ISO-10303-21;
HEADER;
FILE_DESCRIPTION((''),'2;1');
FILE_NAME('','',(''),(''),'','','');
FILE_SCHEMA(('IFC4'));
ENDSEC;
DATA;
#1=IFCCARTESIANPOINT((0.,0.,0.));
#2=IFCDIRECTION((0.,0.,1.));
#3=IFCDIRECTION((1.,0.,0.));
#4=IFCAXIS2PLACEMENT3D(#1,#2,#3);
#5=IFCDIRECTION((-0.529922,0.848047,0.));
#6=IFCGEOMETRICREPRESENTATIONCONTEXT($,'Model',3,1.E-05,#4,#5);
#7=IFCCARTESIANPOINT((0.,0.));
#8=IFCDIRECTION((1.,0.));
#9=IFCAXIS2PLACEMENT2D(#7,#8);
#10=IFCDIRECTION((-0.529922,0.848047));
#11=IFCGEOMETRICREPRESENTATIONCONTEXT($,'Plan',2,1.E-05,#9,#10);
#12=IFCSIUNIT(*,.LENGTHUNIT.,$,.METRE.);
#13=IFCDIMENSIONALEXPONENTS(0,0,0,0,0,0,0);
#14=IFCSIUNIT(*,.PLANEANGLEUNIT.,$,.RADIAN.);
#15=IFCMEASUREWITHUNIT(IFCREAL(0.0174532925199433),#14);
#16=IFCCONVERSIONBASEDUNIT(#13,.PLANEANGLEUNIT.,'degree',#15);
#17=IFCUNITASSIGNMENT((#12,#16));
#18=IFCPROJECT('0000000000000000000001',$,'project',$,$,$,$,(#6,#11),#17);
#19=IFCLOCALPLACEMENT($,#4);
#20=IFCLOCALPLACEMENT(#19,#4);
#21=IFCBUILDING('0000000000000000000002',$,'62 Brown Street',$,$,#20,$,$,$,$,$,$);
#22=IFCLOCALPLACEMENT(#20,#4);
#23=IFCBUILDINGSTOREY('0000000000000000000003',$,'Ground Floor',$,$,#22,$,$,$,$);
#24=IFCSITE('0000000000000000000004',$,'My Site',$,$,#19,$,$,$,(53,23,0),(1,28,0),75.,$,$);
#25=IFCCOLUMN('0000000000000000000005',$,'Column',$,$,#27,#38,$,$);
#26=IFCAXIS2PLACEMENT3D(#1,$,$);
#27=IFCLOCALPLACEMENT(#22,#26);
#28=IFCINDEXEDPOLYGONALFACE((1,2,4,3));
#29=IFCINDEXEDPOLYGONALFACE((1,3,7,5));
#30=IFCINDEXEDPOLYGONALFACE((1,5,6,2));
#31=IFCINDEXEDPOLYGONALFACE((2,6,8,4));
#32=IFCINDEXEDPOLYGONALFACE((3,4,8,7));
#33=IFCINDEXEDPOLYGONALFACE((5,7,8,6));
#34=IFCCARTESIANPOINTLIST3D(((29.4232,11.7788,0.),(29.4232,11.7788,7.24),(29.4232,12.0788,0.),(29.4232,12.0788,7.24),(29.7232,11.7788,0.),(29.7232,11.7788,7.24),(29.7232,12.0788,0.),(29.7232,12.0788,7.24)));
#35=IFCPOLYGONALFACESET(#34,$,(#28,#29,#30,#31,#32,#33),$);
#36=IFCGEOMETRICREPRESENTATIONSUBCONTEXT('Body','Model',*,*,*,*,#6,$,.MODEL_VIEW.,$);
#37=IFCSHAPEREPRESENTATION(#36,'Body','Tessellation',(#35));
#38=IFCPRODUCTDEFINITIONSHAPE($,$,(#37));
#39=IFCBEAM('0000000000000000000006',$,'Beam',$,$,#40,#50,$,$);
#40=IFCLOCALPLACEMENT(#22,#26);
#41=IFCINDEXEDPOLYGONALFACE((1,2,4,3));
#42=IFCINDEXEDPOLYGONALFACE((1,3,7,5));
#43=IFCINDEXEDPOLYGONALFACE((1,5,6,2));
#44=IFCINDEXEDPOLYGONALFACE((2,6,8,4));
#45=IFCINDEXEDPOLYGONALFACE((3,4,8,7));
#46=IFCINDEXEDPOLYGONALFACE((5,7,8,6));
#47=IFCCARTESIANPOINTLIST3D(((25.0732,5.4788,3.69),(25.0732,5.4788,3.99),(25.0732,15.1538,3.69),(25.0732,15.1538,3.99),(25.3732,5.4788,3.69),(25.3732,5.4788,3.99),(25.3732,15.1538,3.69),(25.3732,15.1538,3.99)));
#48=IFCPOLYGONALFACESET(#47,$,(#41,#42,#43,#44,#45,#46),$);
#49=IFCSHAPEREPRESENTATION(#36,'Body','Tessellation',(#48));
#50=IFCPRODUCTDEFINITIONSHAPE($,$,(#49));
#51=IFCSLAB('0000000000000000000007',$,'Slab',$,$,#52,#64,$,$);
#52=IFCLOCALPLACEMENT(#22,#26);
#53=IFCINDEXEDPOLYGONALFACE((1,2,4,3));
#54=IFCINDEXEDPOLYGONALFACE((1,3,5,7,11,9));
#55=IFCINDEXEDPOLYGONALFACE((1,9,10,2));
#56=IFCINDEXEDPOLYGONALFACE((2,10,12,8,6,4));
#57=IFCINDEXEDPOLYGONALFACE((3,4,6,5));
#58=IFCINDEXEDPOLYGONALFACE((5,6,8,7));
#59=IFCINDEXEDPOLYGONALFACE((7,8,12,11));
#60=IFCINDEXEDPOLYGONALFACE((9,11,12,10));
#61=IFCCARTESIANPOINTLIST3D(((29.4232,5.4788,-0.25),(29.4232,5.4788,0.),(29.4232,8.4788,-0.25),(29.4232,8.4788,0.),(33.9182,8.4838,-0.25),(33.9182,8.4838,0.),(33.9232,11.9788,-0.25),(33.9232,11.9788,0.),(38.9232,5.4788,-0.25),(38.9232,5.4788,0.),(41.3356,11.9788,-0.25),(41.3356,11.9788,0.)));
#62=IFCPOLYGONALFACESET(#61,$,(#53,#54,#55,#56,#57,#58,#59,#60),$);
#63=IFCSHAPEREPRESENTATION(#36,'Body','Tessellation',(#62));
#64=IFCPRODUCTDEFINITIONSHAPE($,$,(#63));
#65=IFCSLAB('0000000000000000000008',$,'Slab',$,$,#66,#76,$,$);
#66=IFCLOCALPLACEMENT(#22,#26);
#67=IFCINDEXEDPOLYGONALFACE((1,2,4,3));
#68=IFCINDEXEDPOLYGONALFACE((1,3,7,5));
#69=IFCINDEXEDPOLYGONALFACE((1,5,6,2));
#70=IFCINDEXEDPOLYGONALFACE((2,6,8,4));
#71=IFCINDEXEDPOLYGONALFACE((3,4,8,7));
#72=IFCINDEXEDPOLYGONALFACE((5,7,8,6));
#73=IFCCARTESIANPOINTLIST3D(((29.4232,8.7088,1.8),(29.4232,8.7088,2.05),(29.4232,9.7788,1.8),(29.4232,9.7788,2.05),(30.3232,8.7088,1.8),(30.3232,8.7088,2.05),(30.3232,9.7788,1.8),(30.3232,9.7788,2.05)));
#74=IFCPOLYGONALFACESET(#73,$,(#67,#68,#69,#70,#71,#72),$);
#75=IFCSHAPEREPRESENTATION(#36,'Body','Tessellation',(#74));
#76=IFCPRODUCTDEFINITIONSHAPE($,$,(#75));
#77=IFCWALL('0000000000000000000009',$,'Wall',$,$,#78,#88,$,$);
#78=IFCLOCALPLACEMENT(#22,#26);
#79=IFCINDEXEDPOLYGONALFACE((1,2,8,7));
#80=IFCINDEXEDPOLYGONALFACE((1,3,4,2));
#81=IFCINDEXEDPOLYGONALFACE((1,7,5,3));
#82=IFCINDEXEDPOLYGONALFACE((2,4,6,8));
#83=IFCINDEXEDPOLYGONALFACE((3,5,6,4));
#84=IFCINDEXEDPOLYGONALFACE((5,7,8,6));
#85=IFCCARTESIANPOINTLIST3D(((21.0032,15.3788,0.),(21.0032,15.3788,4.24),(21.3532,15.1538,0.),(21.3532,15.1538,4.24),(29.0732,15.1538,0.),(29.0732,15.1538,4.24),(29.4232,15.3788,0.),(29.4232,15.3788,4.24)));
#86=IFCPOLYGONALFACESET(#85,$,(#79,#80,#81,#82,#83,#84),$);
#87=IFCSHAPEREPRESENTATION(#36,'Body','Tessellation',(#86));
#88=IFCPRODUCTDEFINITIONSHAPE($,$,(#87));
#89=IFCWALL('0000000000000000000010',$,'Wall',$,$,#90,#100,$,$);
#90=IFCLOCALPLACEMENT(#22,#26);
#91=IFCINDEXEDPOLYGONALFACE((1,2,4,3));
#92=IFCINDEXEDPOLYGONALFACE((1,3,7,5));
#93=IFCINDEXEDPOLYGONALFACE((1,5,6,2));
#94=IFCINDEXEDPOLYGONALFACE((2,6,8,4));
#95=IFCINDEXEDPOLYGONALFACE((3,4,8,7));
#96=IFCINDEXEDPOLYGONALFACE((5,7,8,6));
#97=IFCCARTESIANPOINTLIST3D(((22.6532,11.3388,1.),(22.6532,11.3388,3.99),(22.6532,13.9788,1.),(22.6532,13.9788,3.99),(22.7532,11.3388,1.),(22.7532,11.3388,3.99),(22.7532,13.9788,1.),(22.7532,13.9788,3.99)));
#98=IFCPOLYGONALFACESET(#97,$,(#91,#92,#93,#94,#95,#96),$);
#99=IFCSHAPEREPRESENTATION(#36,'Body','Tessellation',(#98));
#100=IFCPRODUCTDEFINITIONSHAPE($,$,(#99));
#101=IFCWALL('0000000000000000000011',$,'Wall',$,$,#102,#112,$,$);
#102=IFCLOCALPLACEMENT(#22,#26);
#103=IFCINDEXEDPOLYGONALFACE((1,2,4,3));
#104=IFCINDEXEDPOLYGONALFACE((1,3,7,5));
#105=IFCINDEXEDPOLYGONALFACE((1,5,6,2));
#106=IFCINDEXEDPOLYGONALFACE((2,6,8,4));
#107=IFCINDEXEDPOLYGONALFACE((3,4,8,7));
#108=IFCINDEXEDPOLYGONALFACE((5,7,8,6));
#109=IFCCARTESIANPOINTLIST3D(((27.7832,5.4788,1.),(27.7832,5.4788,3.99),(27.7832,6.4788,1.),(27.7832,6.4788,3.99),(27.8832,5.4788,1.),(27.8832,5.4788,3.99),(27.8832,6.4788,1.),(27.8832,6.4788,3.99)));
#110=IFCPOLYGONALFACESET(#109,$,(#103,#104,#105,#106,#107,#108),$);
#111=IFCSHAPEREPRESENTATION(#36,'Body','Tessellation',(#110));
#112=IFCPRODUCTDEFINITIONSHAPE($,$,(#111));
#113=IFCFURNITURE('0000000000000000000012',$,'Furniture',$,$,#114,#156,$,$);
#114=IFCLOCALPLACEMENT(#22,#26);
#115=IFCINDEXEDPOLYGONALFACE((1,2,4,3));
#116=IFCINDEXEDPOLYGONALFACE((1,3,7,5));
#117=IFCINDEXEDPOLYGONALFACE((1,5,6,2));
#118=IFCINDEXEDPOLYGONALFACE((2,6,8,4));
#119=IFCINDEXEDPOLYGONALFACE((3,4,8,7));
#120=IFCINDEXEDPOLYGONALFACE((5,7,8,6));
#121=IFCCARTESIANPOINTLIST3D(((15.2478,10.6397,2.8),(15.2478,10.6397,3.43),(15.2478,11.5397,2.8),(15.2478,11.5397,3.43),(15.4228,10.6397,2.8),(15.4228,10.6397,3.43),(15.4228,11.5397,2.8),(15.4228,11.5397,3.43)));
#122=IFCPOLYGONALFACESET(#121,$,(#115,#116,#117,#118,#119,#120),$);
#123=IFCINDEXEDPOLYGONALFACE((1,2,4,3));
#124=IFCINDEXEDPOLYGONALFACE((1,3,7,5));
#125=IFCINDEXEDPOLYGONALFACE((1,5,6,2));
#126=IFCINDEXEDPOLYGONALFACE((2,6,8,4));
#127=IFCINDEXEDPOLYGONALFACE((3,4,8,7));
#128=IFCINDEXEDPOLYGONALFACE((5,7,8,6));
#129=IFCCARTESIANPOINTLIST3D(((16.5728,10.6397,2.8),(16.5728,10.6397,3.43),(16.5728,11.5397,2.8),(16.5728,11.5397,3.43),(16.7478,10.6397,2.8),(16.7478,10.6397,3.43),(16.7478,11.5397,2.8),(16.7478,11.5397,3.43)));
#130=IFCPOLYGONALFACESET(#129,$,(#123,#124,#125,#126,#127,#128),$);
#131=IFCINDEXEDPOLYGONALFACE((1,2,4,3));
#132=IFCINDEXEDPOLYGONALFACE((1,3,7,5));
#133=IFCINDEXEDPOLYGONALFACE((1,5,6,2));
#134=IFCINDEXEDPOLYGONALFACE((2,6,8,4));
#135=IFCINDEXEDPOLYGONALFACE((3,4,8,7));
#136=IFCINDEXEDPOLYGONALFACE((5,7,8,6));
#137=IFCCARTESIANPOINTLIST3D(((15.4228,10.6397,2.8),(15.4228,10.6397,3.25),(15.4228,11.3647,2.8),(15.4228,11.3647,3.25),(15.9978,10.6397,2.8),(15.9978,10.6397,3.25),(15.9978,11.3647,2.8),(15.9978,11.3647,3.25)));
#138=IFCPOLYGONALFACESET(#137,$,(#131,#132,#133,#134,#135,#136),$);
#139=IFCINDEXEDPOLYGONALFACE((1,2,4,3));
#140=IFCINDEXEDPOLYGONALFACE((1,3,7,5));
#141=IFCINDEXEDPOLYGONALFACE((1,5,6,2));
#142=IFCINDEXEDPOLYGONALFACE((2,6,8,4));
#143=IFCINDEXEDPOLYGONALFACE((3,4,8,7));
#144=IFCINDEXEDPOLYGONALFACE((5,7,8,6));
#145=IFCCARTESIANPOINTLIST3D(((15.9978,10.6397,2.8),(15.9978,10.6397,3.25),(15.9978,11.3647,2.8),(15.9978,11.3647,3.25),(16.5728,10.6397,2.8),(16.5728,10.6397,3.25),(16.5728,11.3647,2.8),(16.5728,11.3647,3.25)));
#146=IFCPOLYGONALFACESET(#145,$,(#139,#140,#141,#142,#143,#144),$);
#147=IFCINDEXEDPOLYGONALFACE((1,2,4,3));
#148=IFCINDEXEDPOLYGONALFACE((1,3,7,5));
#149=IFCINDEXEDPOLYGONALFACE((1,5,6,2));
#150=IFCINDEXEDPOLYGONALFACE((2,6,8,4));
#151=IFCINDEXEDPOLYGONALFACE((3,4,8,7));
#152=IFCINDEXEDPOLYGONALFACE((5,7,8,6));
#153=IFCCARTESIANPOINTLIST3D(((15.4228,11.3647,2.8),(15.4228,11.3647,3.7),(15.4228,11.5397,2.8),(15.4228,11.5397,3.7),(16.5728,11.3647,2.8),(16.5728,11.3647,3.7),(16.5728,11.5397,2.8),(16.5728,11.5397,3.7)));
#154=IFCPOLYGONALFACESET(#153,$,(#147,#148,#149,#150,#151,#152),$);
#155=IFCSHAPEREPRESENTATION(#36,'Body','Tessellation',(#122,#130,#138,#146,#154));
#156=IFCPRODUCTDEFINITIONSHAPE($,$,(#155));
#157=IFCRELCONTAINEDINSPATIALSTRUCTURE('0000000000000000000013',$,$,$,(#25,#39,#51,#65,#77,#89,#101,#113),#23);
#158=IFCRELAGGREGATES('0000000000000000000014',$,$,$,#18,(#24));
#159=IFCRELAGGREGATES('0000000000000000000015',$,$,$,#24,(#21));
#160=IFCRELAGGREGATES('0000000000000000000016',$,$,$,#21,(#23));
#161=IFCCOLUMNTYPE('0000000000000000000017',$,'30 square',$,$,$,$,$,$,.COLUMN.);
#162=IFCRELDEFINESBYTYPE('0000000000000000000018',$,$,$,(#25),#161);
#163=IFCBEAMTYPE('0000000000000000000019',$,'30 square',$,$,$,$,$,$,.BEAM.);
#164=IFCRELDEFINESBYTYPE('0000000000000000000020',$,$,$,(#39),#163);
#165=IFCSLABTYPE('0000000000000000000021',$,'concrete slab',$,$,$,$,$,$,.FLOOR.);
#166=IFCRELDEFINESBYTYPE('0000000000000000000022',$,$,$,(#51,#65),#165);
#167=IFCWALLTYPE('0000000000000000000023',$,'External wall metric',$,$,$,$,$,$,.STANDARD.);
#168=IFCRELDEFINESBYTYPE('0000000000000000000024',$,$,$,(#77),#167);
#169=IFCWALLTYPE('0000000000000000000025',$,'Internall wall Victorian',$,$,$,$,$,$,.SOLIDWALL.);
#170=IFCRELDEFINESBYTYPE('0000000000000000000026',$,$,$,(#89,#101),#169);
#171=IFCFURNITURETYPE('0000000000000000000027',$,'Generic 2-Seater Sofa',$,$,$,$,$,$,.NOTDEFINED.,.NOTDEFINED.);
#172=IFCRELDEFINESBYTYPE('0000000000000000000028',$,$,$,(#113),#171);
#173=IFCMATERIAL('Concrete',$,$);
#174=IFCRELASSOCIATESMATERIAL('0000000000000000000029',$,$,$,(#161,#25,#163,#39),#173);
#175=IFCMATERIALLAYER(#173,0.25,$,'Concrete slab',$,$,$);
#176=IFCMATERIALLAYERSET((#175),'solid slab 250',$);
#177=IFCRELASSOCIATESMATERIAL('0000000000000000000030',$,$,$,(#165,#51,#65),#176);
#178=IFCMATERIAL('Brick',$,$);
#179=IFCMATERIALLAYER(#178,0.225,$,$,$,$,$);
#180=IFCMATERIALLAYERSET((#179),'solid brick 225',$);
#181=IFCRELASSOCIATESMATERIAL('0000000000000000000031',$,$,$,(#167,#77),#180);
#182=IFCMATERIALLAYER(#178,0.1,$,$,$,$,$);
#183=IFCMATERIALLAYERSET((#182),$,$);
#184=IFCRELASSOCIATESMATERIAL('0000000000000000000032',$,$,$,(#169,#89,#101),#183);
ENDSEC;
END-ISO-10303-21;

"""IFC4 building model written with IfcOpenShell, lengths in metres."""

from ifc_helpers import new_model, entity, si_unit, converted_unit, direction, frame, origin_with_axes, origin_2d_with_axis, place, context, subcontext, project, spatial, line, indexed_curve, rectangle, outline, extrude, clip, halfspace, shape, source, transform, mapped, material, layer, layer_set, layer_usage, material_profile, profile_set, profile_usage, type_object, type_shapes, element, save


model = new_model("IFC4")

# Units and contexts
model_context = context("Model", 3, precision=1e-05, world=origin_with_axes(), true_north=direction((-0.529922, 0.848047, 0.0)))
plan_context = context("Plan", 2, precision=1e-05, world=origin_2d_with_axis(), true_north=direction((-0.529922, 0.848047)))
body_context_1 = subcontext(model_context, "Body", "Model", "MODEL_VIEW")
body_context_2 = subcontext(plan_context, "Body", "Plan", "PLAN_VIEW")
ifc_project = project(units=[si_unit("LENGTHUNIT", "METRE"), converted_unit("PLANEANGLEUNIT", "degree", entity("IfcReal", 0.0174532925199433), si_unit("PLANEANGLEUNIT", "RADIAN"), dimensions=[0, 0, 0, 0, 0, 0, 0])], contexts=[model_context, plan_context])

# Site, building, storey
site_placement = place(None, origin_with_axes())
site = spatial("IfcSite", under=ifc_project, at=site_placement, Name="My Site", RefLatitude=(53, 23, 0), RefLongitude=(1, 28, 0), RefElevation=75.0)
building_placement = place(site_placement, origin_with_axes())
building = spatial("IfcBuilding", under=site, at=building_placement, Name="62 Brown Street")
storey_placement = place(building_placement, origin_with_axes())
storey = spatial("IfcBuildingStorey", under=building, at=storey_placement, Name="Ground Floor")

# Column
ifc_material_1 = material(Name="Concrete")
ifc_material_profile_1 = material_profile(ifc_material_1, rectangle(XDim=0.3, YDim=0.3))
ifc_profile_set_1 = profile_set([ifc_material_profile_1])
ifc_profile_usage_1 = profile_usage(ifc_profile_set_1, cardinal=5)
column_type = type_object("IfcColumnType", Name="30 square", PredefinedType="COLUMN", material=ifc_profile_set_1)
column_1_placement = place(storey_placement, frame((29.5732, 11.9288, 0.0), z_axis=(0.0, 0.0, 1.0), x_axis=(1.0, 0.0, 0.0)))
element("IfcColumn", 1, at=column_1_placement, inside=storey, type_object=column_type, material=ifc_profile_usage_1, Name="Column", context=body_context_1, shape_type="SweptSolid", body=[
    extrude(rectangle(XDim=0.3, YDim=0.3), origin_with_axes(), (0.0, 0.0, 1.0), 7.24),
])

# Beam
ifc_material_profile_2 = material_profile(ifc_material_1, rectangle(XDim=0.3, YDim=0.3))
ifc_profile_set_2 = profile_set([ifc_material_profile_2])
ifc_profile_usage_2 = profile_usage(ifc_profile_set_2, cardinal=5)
beam_type = type_object("IfcBeamType", Name="30 square", PredefinedType="BEAM", material=ifc_profile_set_2)
beam_placement = place(storey_placement, frame((25.2232, 5.4788, 3.84), z_axis=(0.0, 1.0, 0.0), x_axis=(-1.0, 0.0, 0.0)))
element("IfcBeam", 2, at=beam_placement, inside=storey, type_object=beam_type, material=ifc_profile_usage_2, Name="Beam", context=body_context_1, shape_type="SweptSolid", body=[
    extrude(rectangle(XDim=0.3, YDim=0.3), origin_with_axes(), (0.0, 0.0, 1.0), 9.675),
])

# Slabs
ifc_layer_1 = layer(ifc_material_1, 0.25, Name="Concrete slab")
ifc_layer_set_1 = layer_set([ifc_layer_1], Name="solid slab 250")
ifc_layer_usage_1 = layer_usage(ifc_layer_set_1, "AXIS3", "POSITIVE", 0.0)
slab_type_1 = type_object("IfcSlabType", Name="concrete slab", PredefinedType="FLOOR", material=ifc_layer_set_1)
slab_1_placement = place(storey_placement, frame((29.4232, 5.4788, -0.25), z_axis=(0.0, 0.0, 1.0), x_axis=(1.0, 0.0, 0.0)))
element("IfcSlab", 3, at=slab_1_placement, inside=storey, type_object=slab_type_1, material=ifc_layer_usage_1, Name="Slab", context=body_context_1, shape_type="SweptSolid", body=[
    extrude(outline(indexed_curve([(0.0, 0.0), (9.5, 0.0), (11.9124, 6.5), (0.0, 3.0), (4.5, 6.5), (4.495, 3.005)], segments=[line(1, 2), line(2, 3), line(3, 5), line(5, 6), line(6, 4), line(4, 1)], self_intersect=False)), None, (0.0, 0.0, 1.0), 0.25),
])
ifc_layer_usage_2 = layer_usage(ifc_layer_set_1, "AXIS3", "POSITIVE", 0.0)
slab_2_placement = place(storey_placement, frame((29.4232, 8.7088, 1.8), z_axis=(0.0, 0.0, 1.0), x_axis=(1.0, 0.0, 0.0)))
element("IfcSlab", 4, at=slab_2_placement, inside=storey, type_object=slab_type_1, material=ifc_layer_usage_2, Name="Slab", context=body_context_1, shape_type="SweptSolid", body=[
    extrude(outline(indexed_curve([(0.9, 1.07), (0.9, 0.0), (0.0, 0.0), (0.0, 1.07)], segments=[line(3, 2), line(2, 1), line(1, 4), line(4, 3)], self_intersect=False)), None, (0.0, 0.0, 1.0), 0.25),
])

# Walls
ifc_material_2 = material(Name="Brick")
ifc_layer_2 = layer(ifc_material_2, 0.225)
ifc_layer_set_2 = layer_set([ifc_layer_2], Name="solid brick 225")
wall_type_1 = type_object("IfcWallType", Name="External wall metric", PredefinedType="STANDARD", material=ifc_layer_set_2)
ifc_layer_usage_3 = layer_usage(ifc_layer_set_2, "AXIS2", "POSITIVE", 0.0)
wall_1_placement = place(storey_placement, frame((29.4232, 15.3788, 0.0), z_axis=(0.0, 0.0, 1.0), x_axis=(-1.0, 0.0, 0.0)))
element("IfcWall", 5, at=wall_1_placement, inside=storey, type_object=wall_type_1, material=ifc_layer_usage_3, Name="Wall", context=body_context_1, shape_type="Clipping", body=[
    clip(clip(extrude(outline(indexed_curve([(0.0, 0.0), (0.0, 0.225), (8.42, 0.225), (8.42, 0.0), (0.0, 0.0)], self_intersect=False)), origin_with_axes(), (0.0, 0.0, 1.0), 4.24), halfspace(frame((8.42, 0.0, 0.0), z_axis=(0.540756, 0.841179, 0.0), x_axis=(-0.841179, 0.540756, 0.0)), False)), halfspace(frame((0.0, 0.0, 0.0), z_axis=(-0.540758, 0.841178, 0.0), x_axis=(0.841178, 0.540758, 0.0)), False)),
])
ifc_layer_3 = layer(ifc_material_2, 0.1)
ifc_layer_set_3 = layer_set([ifc_layer_3])
ifc_layer_usage_4 = layer_usage(ifc_layer_set_3, "AXIS2", "POSITIVE", 0.0)
wall_type_2 = type_object("IfcWallType", Name="Internall wall Victorian", PredefinedType="SOLIDWALL", material=ifc_layer_set_3)
wall_2_placement = place(storey_placement, frame((22.7532, 11.3388, 1.0), z_axis=(0.0, 0.0, 1.0), x_axis=(0.0, 1.0, 0.0)))
element("IfcWall", 6, at=wall_2_placement, inside=storey, type_object=wall_type_2, material=ifc_layer_usage_4, Name="Wall", context=body_context_1, shape_type="SweptSolid", body=[
    extrude(outline(indexed_curve([(0.0, 0.0), (0.0, 0.1), (2.64, 0.1), (2.64, 0.0), (0.0, 0.0)], self_intersect=False)), origin_with_axes(), (0.0, 0.0, 1.0), 2.99),
])
ifc_layer_usage_5 = layer_usage(ifc_layer_set_3, "AXIS2", "POSITIVE", 0.0)
wall_3_placement = place(storey_placement, frame((27.8832, 5.4788, 1.0), z_axis=(0.0, 0.0, 1.0), x_axis=(0.0, 1.0, 0.0)))
element("IfcWall", 7, at=wall_3_placement, inside=storey, type_object=wall_type_2, material=ifc_layer_usage_5, Name="Wall", context=body_context_1, shape_type="SweptSolid", body=[
    extrude(outline(indexed_curve([(0.0, 0.0), (0.0, 0.1), (1.0, 0.1), (1.0, 0.0), (0.0, 0.0)], self_intersect=False)), origin_with_axes(), (0.0, 0.0, 1.0), 2.99),
])

# Furniture
furniture_type_1 = type_object("IfcFurnitureType", Name="Generic 2-Seater Sofa", AssemblyPlace="NOTDEFINED", PredefinedType="NOTDEFINED")
shared_shape_1 = source(origin_with_axes(), body_context_1, "Body", "SweptSolid", [
    extrude(outline(indexed_curve([(0.0, 0.0), (0.175, 0.0), (0.175, 0.9), (0.0, 0.9)], segments=[line(1, 2, 3, 4, 1)])), frame((-0.75, -0.9, 0.0), z_axis=(0.0, 0.0, 1.0), x_axis=(1.0, 0.0, 0.0)), (0.0, 0.0, 1.0), 0.63),
    extrude(outline(indexed_curve([(0.0, 0.0), (0.175, 0.0), (0.175, 0.9), (0.0, 0.9)], segments=[line(1, 2, 3, 4, 1)])), frame((0.575, -0.9, 0.0), z_axis=(0.0, 0.0, 1.0), x_axis=(1.0, 0.0, 0.0)), (0.0, 0.0, 1.0), 0.63),
    extrude(outline(indexed_curve([(0.175, 0.0), (0.75, 0.0), (0.75, 0.725), (0.175, 0.725)], segments=[line(1, 2, 3, 4, 1)])), frame((-0.75, -0.9, 0.0), z_axis=(0.0, 0.0, 1.0), x_axis=(1.0, 0.0, 0.0)), (0.0, 0.0, 1.0), 0.45),
    extrude(outline(indexed_curve([(0.75, 0.0), (1.325, 0.0), (1.325, 0.725), (0.75, 0.725)], segments=[line(1, 2, 3, 4, 1)])), frame((-0.75, -0.9, 0.0), z_axis=(0.0, 0.0, 1.0), x_axis=(1.0, 0.0, 0.0)), (0.0, 0.0, 1.0), 0.45),
    extrude(outline(indexed_curve([(0.175, 0.725), (1.325, 0.725), (1.325, 0.9), (0.175, 0.9)], segments=[line(1, 2, 3, 4, 1)])), frame((-0.75, -0.9, 0.0), z_axis=(0.0, 0.0, 1.0), x_axis=(1.0, 0.0, 0.0)), (0.0, 0.0, 1.0), 0.9),
])
shared_shape_2 = source(origin_with_axes(), body_context_2, "Body", "Curve2D", [
    entity("IfcIndexedPolyCurve", entity("IfcCartesianPointList2D", [[-0.75, -0.9], [-0.575, -0.9], [-0.575, 0.0], [-0.75, 0.0]]), [entity("IfcLineIndex", [1, 2, 3, 4, 1])]),
    entity("IfcIndexedPolyCurve", entity("IfcCartesianPointList2D", [[0.575, -0.9], [0.75, -0.9], [0.75, 0.0], [0.575, 0.0]]), [entity("IfcLineIndex", [1, 2, 3, 4, 1])]),
    entity("IfcIndexedPolyCurve", entity("IfcCartesianPointList2D", [[-0.575, -0.9], [0.0, -0.9], [0.0, -0.175], [-0.575, -0.175]]), [entity("IfcLineIndex", [1, 2, 3, 4, 1])]),
    entity("IfcIndexedPolyCurve", entity("IfcCartesianPointList2D", [[0.0, -0.9], [0.575, -0.9], [0.575, -0.175], [0.0, -0.175]]), [entity("IfcLineIndex", [1, 2, 3, 4, 1])]),
    entity("IfcIndexedPolyCurve", entity("IfcCartesianPointList2D", [[-0.575, -0.175], [0.575, -0.175], [0.575, 0.0], [-0.575, 0.0]]), [entity("IfcLineIndex", [1, 2, 3, 4, 1])]),
])
type_shapes(furniture_type_1, [shared_shape_1, shared_shape_2])
furniture_1_placement = place(storey_placement, frame((15.9978, 11.5397, 2.8), z_axis=(0.0, 0.0, 1.0), x_axis=(1.0, 0.0, 0.0)))
element("IfcFurniture", 8, at=furniture_1_placement, inside=storey, type_object=furniture_type_1, Name="Furniture", shapes=[
    shape(body_context_1, "Body", "MappedRepresentation", [mapped(shared_shape_1, transform((0.0, 0.0, 0.0), x_axis=(1.0, 0.0, 0.0), y_axis=(0.0, 1.0, 0.0), z_axis=(0.0, 0.0, 1.0), scale=1.0))]),
    shape(body_context_2, "Body", "MappedRepresentation", [mapped(shared_shape_2, transform((0.0, 0.0, 0.0), x_axis=(1.0, 0.0, 0.0), y_axis=(0.0, 1.0, 0.0), z_axis=(0.0, 0.0, 1.0), scale=1.0))]),
])

save(model, "model.ifc")
